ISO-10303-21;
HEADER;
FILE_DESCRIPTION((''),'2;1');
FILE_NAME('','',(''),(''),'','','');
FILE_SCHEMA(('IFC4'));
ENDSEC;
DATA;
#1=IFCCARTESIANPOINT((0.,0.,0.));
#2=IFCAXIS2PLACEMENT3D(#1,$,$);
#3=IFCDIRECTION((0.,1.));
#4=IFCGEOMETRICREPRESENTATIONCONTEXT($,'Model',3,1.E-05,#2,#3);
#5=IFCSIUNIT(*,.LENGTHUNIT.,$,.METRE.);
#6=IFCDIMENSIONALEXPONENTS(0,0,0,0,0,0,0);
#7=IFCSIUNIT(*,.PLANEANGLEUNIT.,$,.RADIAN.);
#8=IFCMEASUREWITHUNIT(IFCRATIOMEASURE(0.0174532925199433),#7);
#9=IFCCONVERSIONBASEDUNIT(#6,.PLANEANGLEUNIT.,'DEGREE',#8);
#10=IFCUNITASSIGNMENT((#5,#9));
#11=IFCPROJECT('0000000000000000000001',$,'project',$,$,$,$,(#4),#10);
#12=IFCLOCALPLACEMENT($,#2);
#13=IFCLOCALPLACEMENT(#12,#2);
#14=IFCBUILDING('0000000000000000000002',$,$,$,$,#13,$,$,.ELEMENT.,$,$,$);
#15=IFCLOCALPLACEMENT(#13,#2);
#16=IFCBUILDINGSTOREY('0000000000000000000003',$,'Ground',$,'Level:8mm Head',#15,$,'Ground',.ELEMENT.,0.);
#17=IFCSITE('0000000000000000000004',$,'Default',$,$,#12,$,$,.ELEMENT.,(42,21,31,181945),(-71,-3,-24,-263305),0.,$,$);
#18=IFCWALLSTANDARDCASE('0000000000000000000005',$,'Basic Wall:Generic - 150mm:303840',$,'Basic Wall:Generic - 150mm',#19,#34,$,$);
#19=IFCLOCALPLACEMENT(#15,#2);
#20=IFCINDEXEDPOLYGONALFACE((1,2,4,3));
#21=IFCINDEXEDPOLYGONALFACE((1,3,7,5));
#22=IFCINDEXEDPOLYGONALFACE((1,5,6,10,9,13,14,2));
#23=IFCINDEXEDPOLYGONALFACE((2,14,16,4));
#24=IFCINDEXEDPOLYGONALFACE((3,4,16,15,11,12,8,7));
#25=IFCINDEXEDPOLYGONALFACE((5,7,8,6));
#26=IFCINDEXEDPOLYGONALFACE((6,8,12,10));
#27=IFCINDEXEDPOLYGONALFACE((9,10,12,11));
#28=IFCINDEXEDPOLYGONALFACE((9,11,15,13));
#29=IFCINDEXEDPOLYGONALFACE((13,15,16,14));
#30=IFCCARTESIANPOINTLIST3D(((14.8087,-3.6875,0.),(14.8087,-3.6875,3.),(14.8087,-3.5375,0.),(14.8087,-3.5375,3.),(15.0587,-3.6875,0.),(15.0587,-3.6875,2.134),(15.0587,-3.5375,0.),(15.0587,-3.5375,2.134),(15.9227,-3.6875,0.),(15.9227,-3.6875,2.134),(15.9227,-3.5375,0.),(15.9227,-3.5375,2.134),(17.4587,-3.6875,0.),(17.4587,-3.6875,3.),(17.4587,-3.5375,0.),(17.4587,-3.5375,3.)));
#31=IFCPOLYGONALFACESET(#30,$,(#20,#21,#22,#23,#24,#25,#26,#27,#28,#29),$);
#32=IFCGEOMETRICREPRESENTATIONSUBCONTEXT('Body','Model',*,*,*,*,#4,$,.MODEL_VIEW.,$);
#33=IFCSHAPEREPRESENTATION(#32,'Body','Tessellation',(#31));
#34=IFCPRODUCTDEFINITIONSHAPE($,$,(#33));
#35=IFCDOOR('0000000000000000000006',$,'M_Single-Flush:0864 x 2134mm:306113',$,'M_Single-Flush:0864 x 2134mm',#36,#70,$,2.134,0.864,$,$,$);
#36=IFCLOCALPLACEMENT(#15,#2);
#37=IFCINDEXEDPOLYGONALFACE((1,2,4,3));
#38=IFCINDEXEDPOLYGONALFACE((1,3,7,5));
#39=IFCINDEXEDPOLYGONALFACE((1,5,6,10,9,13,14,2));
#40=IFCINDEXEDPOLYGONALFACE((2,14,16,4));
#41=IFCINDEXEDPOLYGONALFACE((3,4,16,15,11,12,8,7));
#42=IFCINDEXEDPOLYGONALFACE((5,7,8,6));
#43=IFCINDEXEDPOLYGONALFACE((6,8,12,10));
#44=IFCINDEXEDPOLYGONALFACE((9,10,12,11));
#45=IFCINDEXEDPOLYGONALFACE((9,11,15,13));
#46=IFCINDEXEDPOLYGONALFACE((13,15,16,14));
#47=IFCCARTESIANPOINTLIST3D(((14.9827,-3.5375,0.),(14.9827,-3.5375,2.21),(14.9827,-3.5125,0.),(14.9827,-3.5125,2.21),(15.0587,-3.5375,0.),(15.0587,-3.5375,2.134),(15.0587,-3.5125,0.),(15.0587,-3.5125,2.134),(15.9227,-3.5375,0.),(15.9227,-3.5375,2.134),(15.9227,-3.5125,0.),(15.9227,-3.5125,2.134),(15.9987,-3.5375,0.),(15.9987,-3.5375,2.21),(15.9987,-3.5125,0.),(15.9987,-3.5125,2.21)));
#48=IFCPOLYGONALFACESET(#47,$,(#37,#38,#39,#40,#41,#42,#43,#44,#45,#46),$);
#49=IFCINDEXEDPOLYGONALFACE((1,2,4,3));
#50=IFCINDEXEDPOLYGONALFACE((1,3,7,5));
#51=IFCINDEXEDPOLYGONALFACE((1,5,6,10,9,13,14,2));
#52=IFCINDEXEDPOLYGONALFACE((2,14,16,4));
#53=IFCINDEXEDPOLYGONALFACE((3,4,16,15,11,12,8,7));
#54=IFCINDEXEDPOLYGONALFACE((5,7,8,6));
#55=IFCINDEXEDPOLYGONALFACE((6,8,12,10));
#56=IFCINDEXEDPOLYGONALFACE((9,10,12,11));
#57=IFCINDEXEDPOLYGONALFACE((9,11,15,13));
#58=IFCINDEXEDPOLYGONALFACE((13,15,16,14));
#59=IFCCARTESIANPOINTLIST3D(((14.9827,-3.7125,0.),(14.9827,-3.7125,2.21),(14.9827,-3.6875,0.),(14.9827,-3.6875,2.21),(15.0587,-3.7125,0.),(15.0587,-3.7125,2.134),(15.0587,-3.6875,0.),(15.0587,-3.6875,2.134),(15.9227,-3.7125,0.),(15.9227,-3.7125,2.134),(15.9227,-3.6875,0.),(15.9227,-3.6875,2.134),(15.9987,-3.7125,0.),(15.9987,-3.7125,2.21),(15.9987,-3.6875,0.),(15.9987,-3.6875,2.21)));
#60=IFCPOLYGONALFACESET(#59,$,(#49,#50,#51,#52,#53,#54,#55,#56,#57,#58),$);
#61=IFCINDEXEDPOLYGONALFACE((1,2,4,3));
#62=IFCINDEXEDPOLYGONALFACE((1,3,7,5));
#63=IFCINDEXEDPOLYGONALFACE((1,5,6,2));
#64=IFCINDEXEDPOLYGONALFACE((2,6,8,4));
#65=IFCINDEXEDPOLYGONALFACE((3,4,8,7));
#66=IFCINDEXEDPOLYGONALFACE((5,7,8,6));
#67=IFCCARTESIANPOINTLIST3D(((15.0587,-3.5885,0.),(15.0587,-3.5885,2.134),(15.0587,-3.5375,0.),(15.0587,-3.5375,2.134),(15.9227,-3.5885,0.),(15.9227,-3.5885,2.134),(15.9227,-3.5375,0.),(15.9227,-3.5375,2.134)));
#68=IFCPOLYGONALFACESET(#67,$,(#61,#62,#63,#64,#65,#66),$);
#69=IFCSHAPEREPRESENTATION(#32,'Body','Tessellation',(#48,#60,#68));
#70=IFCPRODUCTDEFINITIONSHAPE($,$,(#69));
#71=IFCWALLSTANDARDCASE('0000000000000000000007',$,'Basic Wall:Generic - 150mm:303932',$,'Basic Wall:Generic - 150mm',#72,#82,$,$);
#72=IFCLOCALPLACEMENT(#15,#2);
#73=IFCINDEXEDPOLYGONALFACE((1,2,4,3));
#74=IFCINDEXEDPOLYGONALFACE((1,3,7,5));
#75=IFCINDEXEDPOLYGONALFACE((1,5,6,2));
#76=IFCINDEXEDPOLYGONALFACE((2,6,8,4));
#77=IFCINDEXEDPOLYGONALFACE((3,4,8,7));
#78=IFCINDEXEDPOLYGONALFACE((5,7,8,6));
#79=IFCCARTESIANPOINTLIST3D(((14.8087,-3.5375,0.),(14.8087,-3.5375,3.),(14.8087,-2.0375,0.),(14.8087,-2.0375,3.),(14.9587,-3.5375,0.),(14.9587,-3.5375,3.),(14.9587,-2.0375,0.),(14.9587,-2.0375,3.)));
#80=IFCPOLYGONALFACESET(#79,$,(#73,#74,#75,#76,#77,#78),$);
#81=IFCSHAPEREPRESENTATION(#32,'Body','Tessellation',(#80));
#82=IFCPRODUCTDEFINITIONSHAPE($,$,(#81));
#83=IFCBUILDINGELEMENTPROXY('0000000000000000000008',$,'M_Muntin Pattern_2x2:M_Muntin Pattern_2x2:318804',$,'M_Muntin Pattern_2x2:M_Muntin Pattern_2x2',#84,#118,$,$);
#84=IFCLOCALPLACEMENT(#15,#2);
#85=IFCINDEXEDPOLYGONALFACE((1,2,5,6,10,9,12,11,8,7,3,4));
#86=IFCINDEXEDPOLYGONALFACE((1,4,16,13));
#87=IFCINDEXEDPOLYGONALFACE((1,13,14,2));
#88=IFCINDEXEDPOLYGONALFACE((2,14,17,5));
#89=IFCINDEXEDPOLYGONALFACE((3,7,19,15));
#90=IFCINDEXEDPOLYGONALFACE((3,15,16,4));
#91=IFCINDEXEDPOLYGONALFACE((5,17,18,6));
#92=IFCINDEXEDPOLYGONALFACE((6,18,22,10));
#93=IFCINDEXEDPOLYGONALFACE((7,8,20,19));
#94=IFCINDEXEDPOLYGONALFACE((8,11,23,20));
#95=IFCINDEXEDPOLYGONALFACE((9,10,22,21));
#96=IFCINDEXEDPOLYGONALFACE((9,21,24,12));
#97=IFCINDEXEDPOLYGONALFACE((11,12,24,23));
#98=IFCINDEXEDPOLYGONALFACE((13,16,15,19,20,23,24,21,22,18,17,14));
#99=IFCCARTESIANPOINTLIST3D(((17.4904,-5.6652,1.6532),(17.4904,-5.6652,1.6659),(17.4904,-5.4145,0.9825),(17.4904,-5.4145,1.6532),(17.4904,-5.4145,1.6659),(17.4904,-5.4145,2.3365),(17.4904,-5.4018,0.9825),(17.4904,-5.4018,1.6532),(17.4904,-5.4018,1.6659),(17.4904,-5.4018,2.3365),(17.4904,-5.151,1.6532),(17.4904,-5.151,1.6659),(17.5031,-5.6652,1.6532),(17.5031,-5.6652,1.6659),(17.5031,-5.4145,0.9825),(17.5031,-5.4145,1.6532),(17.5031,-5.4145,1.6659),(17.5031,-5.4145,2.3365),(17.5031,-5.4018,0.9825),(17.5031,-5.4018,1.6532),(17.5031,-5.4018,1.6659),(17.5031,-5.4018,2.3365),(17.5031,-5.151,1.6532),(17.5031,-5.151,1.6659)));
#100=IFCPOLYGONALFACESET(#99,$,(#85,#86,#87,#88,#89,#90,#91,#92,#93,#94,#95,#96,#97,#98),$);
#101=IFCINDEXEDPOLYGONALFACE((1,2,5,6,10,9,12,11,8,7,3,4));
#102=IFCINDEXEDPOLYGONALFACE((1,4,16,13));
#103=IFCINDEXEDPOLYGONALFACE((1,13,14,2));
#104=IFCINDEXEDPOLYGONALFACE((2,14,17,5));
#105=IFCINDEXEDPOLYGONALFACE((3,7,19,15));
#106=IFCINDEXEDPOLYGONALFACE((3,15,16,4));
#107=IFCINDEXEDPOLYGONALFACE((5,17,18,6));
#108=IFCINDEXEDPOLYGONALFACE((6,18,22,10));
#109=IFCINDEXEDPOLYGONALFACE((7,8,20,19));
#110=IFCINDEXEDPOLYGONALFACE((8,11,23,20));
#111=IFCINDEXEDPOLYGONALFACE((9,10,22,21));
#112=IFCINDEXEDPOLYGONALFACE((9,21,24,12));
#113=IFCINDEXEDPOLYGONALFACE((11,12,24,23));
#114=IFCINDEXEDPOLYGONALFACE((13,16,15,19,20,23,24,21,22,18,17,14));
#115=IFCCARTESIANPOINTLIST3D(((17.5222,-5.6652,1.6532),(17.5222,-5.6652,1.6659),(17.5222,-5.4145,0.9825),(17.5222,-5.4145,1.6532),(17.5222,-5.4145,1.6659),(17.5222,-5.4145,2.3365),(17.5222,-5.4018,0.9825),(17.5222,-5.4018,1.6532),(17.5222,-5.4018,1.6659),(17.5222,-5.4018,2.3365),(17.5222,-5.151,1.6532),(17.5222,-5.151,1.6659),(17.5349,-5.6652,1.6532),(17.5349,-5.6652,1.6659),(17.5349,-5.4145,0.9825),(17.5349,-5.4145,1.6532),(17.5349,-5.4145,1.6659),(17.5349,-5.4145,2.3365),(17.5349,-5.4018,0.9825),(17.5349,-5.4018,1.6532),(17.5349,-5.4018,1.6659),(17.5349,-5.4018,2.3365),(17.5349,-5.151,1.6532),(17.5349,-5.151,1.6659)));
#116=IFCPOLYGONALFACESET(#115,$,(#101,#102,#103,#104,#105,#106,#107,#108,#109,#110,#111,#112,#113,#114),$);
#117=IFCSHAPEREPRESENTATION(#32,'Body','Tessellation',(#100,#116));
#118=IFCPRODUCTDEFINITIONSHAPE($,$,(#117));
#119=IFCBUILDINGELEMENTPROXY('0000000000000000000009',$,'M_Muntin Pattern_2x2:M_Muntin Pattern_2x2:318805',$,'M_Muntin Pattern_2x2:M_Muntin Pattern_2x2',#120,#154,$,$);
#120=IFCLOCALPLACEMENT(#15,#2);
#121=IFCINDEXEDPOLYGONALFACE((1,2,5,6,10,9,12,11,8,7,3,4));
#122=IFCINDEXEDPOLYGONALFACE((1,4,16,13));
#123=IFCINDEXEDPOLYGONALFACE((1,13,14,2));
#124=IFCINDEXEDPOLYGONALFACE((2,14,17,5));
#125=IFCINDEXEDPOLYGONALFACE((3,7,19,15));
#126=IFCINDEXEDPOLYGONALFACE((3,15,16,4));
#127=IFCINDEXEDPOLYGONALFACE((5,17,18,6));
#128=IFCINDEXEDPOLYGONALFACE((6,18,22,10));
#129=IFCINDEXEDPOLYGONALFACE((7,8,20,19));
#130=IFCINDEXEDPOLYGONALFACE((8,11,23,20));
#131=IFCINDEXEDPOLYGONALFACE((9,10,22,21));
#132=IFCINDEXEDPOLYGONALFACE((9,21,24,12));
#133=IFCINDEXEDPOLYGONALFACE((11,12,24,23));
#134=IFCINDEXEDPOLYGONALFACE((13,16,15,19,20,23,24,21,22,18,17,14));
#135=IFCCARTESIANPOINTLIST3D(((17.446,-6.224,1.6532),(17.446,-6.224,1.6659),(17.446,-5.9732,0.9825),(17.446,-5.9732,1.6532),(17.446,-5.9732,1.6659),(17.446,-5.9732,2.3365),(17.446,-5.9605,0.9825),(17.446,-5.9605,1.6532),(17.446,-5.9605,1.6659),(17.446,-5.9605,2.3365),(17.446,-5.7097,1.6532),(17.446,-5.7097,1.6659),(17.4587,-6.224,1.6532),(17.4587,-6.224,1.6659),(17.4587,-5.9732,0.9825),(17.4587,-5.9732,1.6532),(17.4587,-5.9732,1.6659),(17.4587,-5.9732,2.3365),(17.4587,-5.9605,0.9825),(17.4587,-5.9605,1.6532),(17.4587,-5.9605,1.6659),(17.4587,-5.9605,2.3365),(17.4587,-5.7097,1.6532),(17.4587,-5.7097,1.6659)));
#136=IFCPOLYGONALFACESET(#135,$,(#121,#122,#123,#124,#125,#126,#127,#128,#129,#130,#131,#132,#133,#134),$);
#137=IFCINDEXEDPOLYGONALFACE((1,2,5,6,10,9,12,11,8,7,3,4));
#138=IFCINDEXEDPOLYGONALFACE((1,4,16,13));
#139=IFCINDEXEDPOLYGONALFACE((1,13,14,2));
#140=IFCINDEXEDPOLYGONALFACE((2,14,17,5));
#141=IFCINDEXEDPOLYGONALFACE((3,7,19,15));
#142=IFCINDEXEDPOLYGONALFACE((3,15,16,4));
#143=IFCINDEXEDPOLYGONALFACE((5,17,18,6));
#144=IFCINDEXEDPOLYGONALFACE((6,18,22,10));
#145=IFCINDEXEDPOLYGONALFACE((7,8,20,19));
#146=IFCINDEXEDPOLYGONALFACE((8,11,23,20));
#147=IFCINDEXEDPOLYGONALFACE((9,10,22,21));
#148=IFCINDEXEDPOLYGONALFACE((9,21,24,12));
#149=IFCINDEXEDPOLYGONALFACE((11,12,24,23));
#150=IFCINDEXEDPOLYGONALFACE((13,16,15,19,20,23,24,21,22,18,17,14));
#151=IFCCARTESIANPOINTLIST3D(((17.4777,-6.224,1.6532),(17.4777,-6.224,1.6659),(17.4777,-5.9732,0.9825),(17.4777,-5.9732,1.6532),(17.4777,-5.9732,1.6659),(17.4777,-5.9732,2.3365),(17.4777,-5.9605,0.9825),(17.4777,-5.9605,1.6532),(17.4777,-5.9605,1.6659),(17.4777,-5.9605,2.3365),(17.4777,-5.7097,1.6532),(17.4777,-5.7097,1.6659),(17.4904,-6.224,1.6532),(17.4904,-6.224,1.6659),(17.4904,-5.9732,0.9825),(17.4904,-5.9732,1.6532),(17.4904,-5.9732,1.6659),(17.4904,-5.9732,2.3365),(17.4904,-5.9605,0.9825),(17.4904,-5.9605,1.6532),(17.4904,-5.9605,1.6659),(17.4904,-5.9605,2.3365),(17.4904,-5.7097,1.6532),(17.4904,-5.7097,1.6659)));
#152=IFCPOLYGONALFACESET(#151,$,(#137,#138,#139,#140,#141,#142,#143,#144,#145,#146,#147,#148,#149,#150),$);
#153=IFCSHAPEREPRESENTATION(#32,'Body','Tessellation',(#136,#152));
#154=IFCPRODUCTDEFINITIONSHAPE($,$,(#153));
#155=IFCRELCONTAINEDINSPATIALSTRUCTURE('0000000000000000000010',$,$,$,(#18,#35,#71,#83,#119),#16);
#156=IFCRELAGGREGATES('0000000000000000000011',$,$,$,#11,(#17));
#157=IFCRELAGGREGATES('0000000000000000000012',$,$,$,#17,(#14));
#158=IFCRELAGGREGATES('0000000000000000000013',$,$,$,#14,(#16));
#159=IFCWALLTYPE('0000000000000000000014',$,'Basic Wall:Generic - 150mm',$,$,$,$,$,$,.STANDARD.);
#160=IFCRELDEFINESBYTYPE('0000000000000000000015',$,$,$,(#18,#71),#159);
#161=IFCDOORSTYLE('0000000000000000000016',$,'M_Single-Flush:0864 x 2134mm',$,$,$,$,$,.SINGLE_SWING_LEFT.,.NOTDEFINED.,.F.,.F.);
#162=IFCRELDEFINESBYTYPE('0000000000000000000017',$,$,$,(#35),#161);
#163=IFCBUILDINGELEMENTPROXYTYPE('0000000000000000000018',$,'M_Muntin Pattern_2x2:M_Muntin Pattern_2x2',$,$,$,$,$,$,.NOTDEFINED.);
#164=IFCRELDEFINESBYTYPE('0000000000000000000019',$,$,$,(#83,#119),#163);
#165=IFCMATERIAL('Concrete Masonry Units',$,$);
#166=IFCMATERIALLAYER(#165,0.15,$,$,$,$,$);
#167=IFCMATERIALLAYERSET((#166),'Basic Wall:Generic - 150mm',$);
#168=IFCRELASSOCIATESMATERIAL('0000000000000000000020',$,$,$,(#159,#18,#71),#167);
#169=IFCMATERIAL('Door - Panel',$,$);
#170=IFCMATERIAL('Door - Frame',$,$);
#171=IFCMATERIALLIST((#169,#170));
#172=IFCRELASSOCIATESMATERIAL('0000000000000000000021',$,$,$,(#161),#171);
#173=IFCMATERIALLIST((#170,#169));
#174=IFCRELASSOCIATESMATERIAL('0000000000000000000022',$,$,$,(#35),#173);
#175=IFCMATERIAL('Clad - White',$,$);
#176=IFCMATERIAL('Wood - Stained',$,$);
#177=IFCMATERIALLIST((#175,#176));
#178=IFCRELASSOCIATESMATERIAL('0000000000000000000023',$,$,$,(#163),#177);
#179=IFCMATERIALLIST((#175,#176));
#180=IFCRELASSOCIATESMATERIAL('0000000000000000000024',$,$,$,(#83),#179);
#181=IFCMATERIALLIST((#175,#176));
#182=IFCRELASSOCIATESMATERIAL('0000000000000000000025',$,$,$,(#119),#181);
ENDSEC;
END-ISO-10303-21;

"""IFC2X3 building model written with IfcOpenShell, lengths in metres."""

from ifc_helpers import new_model, entity, si_unit, converted_unit, direction, frame, frame_2d, origin, place, context, subcontext, project, spatial, polyline, rectangle, outline, extrude, source, transform, mapped, material, material_list, layer, layer_set, layer_usage, type_object, type_shapes, element, fill, save


model = new_model("IFC2X3")

# Units and contexts
model_context = context("Model", 3, precision=1e-05, world=origin(), true_north=direction((0.0, 1.0)))
body_context = subcontext(model_context, "Body", "Model", "MODEL_VIEW")
ifc_project = project(units=[si_unit("LENGTHUNIT", "METRE"), converted_unit("PLANEANGLEUNIT", "DEGREE", entity("IfcRatioMeasure", 0.0174532925199433), si_unit("PLANEANGLEUNIT", "RADIAN"), dimensions=[0, 0, 0, 0, 0, 0, 0])], contexts=[model_context])

# Site, building, storey
site_placement = place(None, origin())
site = spatial("IfcSite", under=ifc_project, at=site_placement, Name="Default", CompositionType="ELEMENT", RefLatitude=(42, 21, 31, 181945), RefLongitude=(-71, -3, -24, -263305), RefElevation=0.0)
building_placement = place(site_placement, origin())
building = spatial("IfcBuilding", under=site, at=building_placement, CompositionType="ELEMENT")
storey_placement = place(building_placement, origin())
storey = spatial("IfcBuildingStorey", under=building, at=storey_placement, Name="Ground", ObjectType="Level:8mm Head", LongName="Ground", CompositionType="ELEMENT", Elevation=0.0)

# Shared definitions
ifc_material_1 = material(Name="Concrete Masonry Units")
ifc_layer = layer(ifc_material_1, 0.15)
ifc_layer_set = layer_set([ifc_layer], Name="Basic Wall:Generic - 150mm")
wall_type = type_object("IfcWallType", Name="Basic Wall:Generic - 150mm", PredefinedType="STANDARD", material=ifc_layer_set)

# Shared definitions
ifc_material_2 = material(Name="Door - Frame")
ifc_material_3 = material(Name="Door - Panel")

# Wall, opening, door
ifc_layer_usage_1 = layer_usage(ifc_layer_set, "AXIS2", "NEGATIVE", 0.075)
wall_1_placement = place(storey_placement, frame((17.4587, -3.6125, 0.0), z_axis=(0.0, 0.0, 1.0), x_axis=(-1.0, 0.0, 0.0)))
wall_1 = element("IfcWallStandardCase", 1, at=wall_1_placement, inside=storey, type_object=wall_type, material=ifc_layer_usage_1, Name="Basic Wall:Generic - 150mm:303840", ObjectType="Basic Wall:Generic - 150mm", context=body_context, shape_type="SweptSolid", body=[
    extrude(rectangle(XDim=2.65, YDim=0.15, at=frame_2d((1.325, 0.0), x_axis=(-1.0, 0.0))), origin(), (0.0, 0.0, 1.0), 3.0),
])
opening_1_placement = place(wall_1_placement, frame((2.4, 0.075, 0.0)))
opening_1 = element("IfcOpeningElement", 2, at=opening_1_placement, cuts=wall_1, ObjectType="Opening", context=body_context, shape_type="SweptSolid", body=[
    extrude(rectangle(XDim=0.864, YDim=2.134, at=frame_2d((1.067, 0.432), x_axis=(0.0, -1.0))), frame((0.0, 0.0, 0.0), z_axis=(0.0, -1.0, 0.0), x_axis=(0.0, 0.0, 1.0)), (0.0, 0.0, 1.0), 0.15),
])
ifc_material_list_1 = material_list([ifc_material_2, ifc_material_3])
ifc_material_list_2 = material_list([ifc_material_3, ifc_material_2])
door_style_1 = type_object("IfcDoorStyle", Name="M_Single-Flush:0864 x 2134mm", ConstructionType="NOTDEFINED", OperationType="SINGLE_SWING_LEFT", ParameterTakesPrecedence=False, Sizeable=False, material=ifc_material_list_2)
shared_shape_1 = source(origin(), body_context, "Body", "SweptSolid", [
    extrude(outline(polyline([(-0.508, -1.124), (0.508, -1.124), (0.508, 1.086), (0.432, 1.086), (0.432, -1.048), (-0.432, -1.048), (-0.432, 1.086), (-0.508, 1.086), (-0.508, -1.124)])), frame((0.432, 0.175, 1.086), z_axis=(0.0, -1.0, 0.0), x_axis=(-1.0, 0.0, 0.0)), (0.0, 0.0, 1.0), 0.025),
    extrude(outline(polyline([(-1.124, -0.508), (1.086, -0.508), (1.086, -0.432), (-1.048, -0.432), (-1.048, 0.432), (1.086, 0.432), (1.086, 0.508), (-1.124, 0.508), (-1.124, -0.508)])), frame((0.432, 0.0, 1.086), z_axis=(0.0, -1.0, 0.0), x_axis=(0.0, 0.0, -1.0)), (0.0, 0.0, 1.0), 0.025),
    extrude(rectangle(XDim=0.864, YDim=0.051, at=frame_2d((0.0, 0.0), x_axis=(1.0, 0.0))), frame((0.432, 0.1245, 0.0)), (0.0, 0.0, 1.0), 2.134),
])
type_shapes(door_style_1, [shared_shape_1])
door_1_placement = place(opening_1_placement, frame((0.0, 0.0, 0.0), z_axis=(0.0, 0.0, 1.0), x_axis=(-1.0, 0.0, 0.0)))
door_1 = element("IfcDoor", 3, at=door_1_placement, inside=storey, type_object=door_style_1, material=ifc_material_list_1, Name="M_Single-Flush:0864 x 2134mm:306113", ObjectType="M_Single-Flush:0864 x 2134mm", OverallHeight=2.134, OverallWidth=0.864, context=body_context, shape_type="MappedRepresentation", body=[
    mapped(shared_shape_1, transform((0.0, 0.0, 0.0), scale=1.0)),
])
fill(opening_1, door_1)

# Wall
ifc_layer_usage_2 = layer_usage(ifc_layer_set, "AXIS2", "POSITIVE", -0.075)
wall_2_placement = place(storey_placement, frame((14.8837, -3.5375, 0.0), z_axis=(0.0, 0.0, 1.0), x_axis=(0.0, 1.0, 0.0)))
element("IfcWallStandardCase", 4, at=wall_2_placement, inside=storey, type_object=wall_type, material=ifc_layer_usage_2, Name="Basic Wall:Generic - 150mm:303932", ObjectType="Basic Wall:Generic - 150mm", context=body_context, shape_type="SweptSolid", body=[
    extrude(rectangle(XDim=1.5, YDim=0.15, at=frame_2d((0.75, 0.0), x_axis=(-1.0, 0.0))), origin(), (0.0, 0.0, 1.0), 3.0),
])

# Building element proxies
ifc_material_4 = material(Name="Clad - White")
ifc_material_5 = material(Name="Wood - Stained")
ifc_material_list_3 = material_list([ifc_material_4, ifc_material_5])
ifc_material_list_4 = material_list([ifc_material_4, ifc_material_5])
building_element_proxy_type_1 = type_object("IfcBuildingElementProxyType", Name="M_Muntin Pattern_2x2:M_Muntin Pattern_2x2", PredefinedType="NOTDEFINED", material=ifc_material_list_4)
shared_shape_2 = source(origin(), body_context, "Body", "SweptSolid", [
    extrude(outline(polyline([(0.0064, -0.0064), (0.677, -0.0064), (0.677, 0.0063), (0.0064, 0.0063), (0.0064, 0.2571), (-0.0063, 0.2571), (-0.0063, 0.0063), (-0.677, 0.0063), (-0.677, -0.0064), (-0.0063, -0.0064), (-0.0063, -0.2571), (0.0064, -0.2571), (0.0064, -0.0064)])), frame((0.0, 0.0095, 0.677), z_axis=(0.0, 1.0, 0.0), x_axis=(0.0, 0.0, 1.0)), (0.0, 0.0, 1.0), 0.0127),
    extrude(outline(polyline([(0.0064, -0.0064), (0.677, -0.0064), (0.677, 0.0063), (0.0064, 0.0063), (0.0064, 0.2571), (-0.0063, 0.2571), (-0.0063, 0.0063), (-0.677, 0.0063), (-0.677, -0.0064), (-0.0063, -0.0064), (-0.0063, -0.2571), (0.0064, -0.2571), (0.0064, -0.0064)])), frame((0.0, -0.0222, 0.677), z_axis=(0.0, 1.0, 0.0), x_axis=(0.0, 0.0, 1.0)), (0.0, 0.0, 1.0), 0.0127),
])
type_shapes(building_element_proxy_type_1, [shared_shape_2])
proxy_1_placement = place(storey_placement, frame((17.5126, -5.4081, 0.9825), z_axis=(0.0, 0.0, 1.0), x_axis=(0.0, 1.0, 0.0)))
element("IfcBuildingElementProxy", 5, at=proxy_1_placement, inside=storey, type_object=building_element_proxy_type_1, material=ifc_material_list_3, Name="M_Muntin Pattern_2x2:M_Muntin Pattern_2x2:318804", ObjectType="M_Muntin Pattern_2x2:M_Muntin Pattern_2x2", context=body_context, shape_type="MappedRepresentation", body=[
    mapped(shared_shape_2, transform((0.0, 0.0, 0.0), scale=1.0)),
])
ifc_material_list_5 = material_list([ifc_material_4, ifc_material_5])
proxy_2_placement = place(storey_placement, frame((17.4682, -5.9668, 0.9825), z_axis=(0.0, 0.0, 1.0), x_axis=(0.0, 1.0, 0.0)))
element("IfcBuildingElementProxy", 6, at=proxy_2_placement, inside=storey, type_object=building_element_proxy_type_1, material=ifc_material_list_5, Name="M_Muntin Pattern_2x2:M_Muntin Pattern_2x2:318805", ObjectType="M_Muntin Pattern_2x2:M_Muntin Pattern_2x2", context=body_context, shape_type="MappedRepresentation", body=[
    mapped(shared_shape_2, transform((0.0, 0.0, 0.0), scale=1.0)),
])

save(model, "model.ifc")
